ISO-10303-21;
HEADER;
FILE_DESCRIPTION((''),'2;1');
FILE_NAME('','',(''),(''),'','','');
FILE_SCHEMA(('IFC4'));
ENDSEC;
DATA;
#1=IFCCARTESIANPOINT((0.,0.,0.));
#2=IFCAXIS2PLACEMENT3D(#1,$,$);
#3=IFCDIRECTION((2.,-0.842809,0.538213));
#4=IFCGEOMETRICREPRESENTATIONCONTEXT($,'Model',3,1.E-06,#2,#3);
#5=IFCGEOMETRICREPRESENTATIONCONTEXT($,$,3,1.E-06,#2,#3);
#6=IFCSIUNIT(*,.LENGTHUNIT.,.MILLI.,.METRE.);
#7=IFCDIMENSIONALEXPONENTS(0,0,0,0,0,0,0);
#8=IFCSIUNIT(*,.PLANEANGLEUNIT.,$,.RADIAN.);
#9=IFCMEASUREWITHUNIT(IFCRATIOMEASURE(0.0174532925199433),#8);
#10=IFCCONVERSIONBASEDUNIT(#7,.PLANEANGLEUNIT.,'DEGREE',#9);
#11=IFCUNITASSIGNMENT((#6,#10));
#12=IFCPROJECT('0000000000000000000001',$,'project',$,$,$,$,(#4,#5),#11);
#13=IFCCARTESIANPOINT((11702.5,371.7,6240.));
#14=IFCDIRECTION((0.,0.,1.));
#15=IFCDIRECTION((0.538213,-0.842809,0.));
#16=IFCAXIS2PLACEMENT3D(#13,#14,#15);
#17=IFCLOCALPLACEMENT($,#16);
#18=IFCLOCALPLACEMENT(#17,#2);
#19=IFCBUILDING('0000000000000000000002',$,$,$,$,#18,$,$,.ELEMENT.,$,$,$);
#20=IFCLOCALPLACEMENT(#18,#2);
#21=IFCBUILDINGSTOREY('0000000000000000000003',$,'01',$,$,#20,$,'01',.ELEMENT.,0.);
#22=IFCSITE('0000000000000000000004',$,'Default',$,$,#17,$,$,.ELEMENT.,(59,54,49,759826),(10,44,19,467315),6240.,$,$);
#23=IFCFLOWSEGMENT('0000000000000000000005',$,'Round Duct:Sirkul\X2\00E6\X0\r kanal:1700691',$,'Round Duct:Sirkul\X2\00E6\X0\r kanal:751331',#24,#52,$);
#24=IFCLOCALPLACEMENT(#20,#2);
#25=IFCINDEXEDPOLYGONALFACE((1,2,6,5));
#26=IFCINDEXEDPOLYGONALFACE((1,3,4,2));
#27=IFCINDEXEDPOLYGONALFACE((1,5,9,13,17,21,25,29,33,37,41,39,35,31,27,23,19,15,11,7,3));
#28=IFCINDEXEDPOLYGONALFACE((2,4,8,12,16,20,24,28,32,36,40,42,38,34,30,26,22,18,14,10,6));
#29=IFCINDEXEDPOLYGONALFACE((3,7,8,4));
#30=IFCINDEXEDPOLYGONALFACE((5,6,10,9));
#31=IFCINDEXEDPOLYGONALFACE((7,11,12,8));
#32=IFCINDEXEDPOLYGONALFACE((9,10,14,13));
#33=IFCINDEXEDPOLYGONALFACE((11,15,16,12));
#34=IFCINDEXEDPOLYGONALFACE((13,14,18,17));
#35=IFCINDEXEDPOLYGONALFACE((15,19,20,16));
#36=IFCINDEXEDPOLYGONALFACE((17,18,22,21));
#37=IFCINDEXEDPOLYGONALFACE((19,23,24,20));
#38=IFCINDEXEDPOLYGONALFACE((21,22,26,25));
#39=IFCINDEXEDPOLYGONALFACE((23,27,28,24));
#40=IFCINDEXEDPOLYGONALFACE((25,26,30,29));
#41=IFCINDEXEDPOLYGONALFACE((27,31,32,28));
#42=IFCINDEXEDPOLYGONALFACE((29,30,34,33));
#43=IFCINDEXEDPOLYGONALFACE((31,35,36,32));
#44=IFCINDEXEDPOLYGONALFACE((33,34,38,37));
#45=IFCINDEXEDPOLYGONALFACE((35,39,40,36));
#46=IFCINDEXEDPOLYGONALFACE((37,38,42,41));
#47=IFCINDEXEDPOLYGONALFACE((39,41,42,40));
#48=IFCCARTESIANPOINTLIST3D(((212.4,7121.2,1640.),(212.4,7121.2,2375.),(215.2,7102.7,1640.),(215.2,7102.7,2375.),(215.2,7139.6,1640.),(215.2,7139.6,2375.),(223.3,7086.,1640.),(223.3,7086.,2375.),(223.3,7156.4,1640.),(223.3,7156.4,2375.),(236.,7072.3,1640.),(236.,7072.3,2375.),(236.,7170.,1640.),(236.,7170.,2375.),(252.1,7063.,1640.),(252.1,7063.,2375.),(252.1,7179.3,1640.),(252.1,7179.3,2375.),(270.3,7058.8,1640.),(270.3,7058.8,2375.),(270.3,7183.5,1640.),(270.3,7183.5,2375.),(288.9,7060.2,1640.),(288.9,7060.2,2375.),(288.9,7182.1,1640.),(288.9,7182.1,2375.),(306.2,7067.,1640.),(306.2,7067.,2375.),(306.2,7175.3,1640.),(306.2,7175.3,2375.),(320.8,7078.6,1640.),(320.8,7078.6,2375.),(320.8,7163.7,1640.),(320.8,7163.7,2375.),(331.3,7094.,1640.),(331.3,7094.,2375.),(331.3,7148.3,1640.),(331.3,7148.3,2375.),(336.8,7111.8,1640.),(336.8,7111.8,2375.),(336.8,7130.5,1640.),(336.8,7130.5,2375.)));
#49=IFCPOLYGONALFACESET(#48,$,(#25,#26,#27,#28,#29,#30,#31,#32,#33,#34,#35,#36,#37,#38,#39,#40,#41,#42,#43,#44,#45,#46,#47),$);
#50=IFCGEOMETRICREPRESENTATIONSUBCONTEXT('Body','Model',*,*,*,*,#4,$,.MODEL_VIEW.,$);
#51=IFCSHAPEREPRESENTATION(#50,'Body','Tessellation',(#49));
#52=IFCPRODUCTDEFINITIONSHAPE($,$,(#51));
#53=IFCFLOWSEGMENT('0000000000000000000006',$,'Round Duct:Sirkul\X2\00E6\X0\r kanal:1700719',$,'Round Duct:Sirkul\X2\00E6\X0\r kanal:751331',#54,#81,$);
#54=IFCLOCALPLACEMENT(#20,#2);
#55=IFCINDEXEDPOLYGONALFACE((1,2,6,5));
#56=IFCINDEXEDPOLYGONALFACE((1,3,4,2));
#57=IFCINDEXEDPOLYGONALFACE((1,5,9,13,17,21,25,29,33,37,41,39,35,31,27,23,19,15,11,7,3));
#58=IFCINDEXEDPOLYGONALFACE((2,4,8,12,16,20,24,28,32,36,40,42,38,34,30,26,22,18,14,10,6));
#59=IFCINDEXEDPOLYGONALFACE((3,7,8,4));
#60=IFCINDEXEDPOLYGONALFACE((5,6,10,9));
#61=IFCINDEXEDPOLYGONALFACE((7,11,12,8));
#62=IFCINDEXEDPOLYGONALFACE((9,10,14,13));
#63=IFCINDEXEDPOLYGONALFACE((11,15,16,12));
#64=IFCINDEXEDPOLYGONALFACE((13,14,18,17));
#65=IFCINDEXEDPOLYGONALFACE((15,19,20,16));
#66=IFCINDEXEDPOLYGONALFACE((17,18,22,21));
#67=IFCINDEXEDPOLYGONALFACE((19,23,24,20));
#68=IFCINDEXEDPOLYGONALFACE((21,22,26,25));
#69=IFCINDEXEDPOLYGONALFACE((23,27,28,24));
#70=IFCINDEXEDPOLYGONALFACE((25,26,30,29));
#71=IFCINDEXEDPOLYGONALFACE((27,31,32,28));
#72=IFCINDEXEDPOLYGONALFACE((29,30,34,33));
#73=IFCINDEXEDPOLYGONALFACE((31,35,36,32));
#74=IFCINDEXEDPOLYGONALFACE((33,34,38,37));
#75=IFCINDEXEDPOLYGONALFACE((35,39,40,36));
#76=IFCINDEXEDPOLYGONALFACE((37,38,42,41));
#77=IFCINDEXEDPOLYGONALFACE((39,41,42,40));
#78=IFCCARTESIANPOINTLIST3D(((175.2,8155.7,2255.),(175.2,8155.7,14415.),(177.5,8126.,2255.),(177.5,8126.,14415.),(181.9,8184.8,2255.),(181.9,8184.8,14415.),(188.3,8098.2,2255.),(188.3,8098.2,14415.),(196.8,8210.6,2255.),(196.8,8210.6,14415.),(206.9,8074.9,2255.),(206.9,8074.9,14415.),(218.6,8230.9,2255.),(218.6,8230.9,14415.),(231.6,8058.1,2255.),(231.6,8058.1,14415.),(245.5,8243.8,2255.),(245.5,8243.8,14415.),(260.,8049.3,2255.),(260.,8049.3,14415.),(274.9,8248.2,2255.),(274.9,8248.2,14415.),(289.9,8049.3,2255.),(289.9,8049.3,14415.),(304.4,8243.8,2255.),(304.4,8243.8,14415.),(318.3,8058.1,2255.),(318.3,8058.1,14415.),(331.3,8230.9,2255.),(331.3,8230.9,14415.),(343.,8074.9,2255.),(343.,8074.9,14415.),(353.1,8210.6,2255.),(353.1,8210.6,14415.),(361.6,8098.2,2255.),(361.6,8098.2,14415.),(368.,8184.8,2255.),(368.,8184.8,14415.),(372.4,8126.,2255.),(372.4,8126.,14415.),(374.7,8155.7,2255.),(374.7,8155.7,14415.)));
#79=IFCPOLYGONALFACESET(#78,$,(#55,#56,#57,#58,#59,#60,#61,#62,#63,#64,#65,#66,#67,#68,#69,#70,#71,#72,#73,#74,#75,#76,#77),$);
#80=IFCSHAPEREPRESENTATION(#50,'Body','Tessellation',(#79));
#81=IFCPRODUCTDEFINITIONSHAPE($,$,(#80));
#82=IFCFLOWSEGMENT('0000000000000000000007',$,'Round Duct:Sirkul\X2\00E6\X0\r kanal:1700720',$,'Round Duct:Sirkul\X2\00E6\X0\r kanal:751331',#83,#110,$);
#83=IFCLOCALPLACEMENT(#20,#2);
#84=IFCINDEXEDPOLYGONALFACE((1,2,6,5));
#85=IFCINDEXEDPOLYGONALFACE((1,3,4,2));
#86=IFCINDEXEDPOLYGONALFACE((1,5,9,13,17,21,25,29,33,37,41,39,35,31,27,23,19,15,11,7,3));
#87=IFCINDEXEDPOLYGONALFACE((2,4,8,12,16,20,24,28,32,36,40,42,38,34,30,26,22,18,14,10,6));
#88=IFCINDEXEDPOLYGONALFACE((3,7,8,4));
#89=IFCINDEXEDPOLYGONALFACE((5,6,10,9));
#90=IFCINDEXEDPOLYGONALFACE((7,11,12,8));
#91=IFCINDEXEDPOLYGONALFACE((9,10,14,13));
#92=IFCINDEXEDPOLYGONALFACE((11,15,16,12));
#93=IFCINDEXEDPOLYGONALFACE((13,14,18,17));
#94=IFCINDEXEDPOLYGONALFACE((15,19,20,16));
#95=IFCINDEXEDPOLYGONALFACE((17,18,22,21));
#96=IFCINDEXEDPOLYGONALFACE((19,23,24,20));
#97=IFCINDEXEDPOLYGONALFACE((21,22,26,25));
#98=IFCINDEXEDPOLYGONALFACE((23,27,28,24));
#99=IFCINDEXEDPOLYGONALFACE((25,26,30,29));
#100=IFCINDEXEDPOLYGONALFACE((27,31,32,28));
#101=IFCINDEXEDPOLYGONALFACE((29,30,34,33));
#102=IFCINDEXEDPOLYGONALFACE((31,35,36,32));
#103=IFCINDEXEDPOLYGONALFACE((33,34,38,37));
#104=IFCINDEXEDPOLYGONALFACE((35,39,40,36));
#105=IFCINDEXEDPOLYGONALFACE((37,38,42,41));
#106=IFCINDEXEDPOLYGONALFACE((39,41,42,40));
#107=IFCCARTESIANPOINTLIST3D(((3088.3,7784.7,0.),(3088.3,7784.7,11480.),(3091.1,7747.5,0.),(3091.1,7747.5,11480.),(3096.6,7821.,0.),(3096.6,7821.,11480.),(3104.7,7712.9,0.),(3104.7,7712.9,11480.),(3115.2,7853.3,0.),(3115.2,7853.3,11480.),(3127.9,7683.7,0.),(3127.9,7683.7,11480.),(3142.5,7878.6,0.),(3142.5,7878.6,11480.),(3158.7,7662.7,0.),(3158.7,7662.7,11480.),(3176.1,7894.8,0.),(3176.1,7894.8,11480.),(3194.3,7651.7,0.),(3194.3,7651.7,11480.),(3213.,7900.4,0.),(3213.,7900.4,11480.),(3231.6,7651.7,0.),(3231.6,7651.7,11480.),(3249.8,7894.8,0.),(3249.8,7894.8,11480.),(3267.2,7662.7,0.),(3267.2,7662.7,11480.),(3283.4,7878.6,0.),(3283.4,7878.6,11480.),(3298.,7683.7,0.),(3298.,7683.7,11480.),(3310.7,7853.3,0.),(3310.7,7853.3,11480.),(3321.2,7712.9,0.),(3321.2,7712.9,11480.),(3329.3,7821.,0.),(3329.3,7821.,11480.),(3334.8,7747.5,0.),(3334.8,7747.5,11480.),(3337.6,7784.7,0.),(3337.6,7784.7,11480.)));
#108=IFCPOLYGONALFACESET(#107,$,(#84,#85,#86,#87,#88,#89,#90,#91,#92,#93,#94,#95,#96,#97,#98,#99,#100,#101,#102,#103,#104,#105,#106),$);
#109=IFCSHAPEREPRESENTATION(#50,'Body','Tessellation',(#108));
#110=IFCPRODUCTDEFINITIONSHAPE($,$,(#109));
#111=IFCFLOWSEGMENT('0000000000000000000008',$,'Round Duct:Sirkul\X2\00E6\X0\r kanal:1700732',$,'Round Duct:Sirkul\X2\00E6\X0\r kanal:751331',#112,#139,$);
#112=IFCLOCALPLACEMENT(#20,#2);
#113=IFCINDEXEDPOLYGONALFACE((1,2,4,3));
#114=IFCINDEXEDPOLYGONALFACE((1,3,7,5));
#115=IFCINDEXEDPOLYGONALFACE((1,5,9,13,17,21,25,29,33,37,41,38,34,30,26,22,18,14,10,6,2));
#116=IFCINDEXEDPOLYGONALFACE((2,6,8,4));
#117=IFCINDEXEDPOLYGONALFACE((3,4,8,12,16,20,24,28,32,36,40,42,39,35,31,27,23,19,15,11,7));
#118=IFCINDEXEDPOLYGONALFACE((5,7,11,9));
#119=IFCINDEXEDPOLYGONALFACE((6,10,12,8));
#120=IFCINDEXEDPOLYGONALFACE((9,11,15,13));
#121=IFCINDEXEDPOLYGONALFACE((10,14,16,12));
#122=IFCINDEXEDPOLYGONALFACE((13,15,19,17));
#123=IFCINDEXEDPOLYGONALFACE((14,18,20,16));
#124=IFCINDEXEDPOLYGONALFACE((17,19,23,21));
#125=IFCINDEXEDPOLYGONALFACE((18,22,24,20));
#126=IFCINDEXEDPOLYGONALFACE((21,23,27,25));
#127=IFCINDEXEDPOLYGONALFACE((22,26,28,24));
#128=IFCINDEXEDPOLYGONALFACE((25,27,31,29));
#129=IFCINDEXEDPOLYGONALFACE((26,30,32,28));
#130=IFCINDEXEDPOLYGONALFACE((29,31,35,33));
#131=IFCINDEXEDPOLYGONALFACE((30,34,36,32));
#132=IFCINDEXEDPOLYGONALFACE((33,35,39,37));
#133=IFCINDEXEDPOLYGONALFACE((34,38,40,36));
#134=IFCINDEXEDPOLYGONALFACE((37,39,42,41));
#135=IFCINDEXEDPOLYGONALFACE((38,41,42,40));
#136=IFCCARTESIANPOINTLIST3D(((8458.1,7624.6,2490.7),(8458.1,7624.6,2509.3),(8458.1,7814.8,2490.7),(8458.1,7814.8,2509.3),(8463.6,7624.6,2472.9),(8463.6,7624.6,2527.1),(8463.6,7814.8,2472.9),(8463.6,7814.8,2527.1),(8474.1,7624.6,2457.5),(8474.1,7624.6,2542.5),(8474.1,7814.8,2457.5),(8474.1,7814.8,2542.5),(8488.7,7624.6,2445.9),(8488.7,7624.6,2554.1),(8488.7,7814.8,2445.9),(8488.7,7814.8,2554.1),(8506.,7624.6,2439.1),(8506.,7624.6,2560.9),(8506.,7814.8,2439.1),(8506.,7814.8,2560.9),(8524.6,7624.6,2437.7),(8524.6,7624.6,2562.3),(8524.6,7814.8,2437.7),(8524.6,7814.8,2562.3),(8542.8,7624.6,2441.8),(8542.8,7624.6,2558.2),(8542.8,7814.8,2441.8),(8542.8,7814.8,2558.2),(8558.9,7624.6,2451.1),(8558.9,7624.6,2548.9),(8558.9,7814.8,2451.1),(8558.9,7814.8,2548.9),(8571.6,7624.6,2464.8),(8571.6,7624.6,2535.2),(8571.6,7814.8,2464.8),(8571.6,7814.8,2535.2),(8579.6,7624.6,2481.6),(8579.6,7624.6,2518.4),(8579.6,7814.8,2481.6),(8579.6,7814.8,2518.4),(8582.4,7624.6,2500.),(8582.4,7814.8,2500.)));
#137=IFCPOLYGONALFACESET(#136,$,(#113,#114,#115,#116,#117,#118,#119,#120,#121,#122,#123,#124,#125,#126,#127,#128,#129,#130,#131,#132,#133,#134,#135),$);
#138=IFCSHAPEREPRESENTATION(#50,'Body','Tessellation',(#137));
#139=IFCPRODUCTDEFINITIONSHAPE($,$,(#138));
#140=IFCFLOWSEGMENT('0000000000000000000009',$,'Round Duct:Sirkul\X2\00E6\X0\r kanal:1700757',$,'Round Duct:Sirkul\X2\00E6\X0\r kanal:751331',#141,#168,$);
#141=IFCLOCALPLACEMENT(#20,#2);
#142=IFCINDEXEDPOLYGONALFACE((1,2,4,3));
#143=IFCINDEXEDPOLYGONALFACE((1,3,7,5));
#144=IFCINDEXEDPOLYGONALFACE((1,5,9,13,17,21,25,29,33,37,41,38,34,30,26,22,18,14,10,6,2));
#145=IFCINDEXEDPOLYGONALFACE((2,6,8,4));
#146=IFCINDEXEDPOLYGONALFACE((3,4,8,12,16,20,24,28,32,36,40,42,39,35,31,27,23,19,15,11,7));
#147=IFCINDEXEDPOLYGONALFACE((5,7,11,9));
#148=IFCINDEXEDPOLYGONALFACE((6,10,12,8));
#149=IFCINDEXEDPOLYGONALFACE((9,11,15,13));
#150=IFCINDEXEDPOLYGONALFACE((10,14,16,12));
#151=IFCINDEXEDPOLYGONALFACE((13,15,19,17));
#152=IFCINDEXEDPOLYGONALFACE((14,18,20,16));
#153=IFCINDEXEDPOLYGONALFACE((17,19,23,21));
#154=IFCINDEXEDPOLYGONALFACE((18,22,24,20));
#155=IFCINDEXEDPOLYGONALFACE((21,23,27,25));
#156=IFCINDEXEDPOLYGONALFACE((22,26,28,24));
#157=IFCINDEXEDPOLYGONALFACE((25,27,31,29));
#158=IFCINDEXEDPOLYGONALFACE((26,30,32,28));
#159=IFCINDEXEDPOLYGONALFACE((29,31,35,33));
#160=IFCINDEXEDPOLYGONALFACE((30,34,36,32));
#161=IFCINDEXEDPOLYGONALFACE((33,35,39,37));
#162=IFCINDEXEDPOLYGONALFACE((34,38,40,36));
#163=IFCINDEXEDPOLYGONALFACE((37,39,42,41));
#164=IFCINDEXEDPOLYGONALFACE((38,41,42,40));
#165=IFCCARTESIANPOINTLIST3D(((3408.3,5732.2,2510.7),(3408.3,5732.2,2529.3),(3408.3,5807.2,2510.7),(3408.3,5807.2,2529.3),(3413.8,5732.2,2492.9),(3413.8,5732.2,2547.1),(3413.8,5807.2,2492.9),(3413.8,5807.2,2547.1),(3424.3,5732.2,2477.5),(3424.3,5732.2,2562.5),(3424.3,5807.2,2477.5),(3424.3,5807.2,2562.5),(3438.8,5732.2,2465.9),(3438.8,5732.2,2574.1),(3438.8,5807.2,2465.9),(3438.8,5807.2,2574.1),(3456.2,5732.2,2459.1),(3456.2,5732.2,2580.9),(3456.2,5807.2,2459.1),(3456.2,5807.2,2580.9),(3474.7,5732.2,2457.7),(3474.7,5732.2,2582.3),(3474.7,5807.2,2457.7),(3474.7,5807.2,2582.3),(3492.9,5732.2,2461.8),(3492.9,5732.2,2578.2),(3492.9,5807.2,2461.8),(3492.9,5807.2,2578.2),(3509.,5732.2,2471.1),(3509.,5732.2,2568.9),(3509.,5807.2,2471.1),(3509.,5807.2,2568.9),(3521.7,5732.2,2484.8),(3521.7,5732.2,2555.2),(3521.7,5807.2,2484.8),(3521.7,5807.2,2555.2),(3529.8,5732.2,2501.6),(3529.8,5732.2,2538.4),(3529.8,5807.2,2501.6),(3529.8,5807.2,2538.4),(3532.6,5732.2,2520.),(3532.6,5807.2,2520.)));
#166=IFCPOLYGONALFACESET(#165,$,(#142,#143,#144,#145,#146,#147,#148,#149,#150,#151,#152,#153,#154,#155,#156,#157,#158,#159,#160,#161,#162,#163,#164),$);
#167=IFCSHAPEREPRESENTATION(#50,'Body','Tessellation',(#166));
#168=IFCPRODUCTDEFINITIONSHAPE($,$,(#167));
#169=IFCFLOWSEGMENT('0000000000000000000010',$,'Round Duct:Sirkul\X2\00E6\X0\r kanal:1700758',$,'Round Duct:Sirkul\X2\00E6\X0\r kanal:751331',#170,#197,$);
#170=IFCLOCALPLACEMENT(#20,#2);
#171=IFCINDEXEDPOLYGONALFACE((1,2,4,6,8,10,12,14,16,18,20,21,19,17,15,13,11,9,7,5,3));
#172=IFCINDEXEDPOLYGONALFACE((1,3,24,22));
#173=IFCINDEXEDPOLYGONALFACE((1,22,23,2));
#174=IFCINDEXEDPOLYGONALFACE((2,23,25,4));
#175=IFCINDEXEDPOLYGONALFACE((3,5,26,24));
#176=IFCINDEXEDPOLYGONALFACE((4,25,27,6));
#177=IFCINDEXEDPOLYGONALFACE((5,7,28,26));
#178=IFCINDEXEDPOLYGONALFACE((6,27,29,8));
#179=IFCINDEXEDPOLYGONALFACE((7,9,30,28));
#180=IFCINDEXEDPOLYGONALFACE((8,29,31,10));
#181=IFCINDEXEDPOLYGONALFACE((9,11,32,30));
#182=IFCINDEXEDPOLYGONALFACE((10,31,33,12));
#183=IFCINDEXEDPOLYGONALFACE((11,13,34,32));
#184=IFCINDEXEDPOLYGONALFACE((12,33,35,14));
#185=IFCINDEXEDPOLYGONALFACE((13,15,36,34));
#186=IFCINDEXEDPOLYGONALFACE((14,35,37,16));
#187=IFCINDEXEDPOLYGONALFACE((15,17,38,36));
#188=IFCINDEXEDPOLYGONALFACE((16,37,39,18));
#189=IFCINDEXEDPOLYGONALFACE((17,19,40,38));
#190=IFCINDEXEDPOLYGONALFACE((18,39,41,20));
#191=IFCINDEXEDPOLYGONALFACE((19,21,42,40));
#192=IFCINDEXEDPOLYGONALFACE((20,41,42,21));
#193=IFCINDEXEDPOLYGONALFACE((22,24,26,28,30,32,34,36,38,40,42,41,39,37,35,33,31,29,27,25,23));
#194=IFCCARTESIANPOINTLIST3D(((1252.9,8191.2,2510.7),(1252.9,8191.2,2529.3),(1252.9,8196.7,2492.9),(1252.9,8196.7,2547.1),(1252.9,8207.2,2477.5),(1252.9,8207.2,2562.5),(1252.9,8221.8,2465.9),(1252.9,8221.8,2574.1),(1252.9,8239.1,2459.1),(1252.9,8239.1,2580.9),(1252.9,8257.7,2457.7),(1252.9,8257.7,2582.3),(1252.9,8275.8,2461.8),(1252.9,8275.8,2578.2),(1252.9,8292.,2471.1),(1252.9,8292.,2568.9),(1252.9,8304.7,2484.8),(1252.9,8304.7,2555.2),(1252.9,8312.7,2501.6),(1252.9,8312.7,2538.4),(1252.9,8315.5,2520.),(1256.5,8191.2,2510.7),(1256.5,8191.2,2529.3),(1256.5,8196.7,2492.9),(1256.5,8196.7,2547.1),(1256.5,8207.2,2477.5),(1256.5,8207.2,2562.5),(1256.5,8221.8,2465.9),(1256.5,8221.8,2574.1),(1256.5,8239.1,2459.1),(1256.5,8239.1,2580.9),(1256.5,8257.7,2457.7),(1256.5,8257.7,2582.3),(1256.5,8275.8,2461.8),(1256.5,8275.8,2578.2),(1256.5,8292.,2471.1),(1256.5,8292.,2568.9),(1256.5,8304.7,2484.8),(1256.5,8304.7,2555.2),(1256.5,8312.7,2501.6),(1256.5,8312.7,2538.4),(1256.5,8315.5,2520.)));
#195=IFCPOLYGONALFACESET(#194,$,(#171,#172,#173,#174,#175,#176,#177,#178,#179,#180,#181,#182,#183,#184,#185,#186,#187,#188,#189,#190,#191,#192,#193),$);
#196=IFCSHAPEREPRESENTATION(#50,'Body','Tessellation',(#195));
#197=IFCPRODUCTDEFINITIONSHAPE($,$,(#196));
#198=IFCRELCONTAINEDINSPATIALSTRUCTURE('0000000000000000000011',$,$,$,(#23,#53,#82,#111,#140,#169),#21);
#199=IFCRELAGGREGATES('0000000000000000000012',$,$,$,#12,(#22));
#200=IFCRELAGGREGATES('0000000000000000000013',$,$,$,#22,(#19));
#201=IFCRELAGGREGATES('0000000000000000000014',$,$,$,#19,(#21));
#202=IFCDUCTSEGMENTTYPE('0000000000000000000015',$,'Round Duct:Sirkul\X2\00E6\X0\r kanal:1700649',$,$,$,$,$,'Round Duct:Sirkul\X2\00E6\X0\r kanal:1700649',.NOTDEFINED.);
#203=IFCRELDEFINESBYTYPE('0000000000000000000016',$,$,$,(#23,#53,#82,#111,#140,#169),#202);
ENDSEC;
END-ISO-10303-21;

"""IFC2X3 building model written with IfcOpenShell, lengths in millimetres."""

from ifc_helpers import new_model, entity, si_unit, converted_unit, direction, frame, frame_2d, origin, origin_2d_with_axis, place, context, subcontext, project, spatial, circle, extrude, type_object, element, save


model = new_model("IFC2X3")

# Units and contexts
model_context = context("Model", 3, precision=1e-06, world=origin(), true_north=direction((2.0, -0.842809, 0.538213)))
context_of_model = context(None, 3, precision=1e-06, world=origin(), true_north=direction((2.0, -0.842809, 0.538213)))
body_context = subcontext(model_context, "Body", "Model", "MODEL_VIEW")
ifc_project = project(units=[si_unit("LENGTHUNIT", "METRE", prefix="MILLI"), converted_unit("PLANEANGLEUNIT", "DEGREE", entity("IfcRatioMeasure", 0.0174532925199433), si_unit("PLANEANGLEUNIT", "RADIAN"), dimensions=[0, 0, 0, 0, 0, 0, 0])], contexts=[model_context, context_of_model])

# Site, building, storey
site_placement = place(None, frame((11702.5, 371.7, 6240.0), z_axis=(0.0, 0.0, 1.0), x_axis=(0.538213, -0.842809, 0.0)))
site = spatial("IfcSite", under=ifc_project, at=site_placement, Name="Default", CompositionType="ELEMENT", RefLatitude=(59, 54, 49, 759826), RefLongitude=(10, 44, 19, 467315), RefElevation=6240.0)
building_placement = place(site_placement, origin())
building = spatial("IfcBuilding", under=site, at=building_placement, CompositionType="ELEMENT")
storey_placement = place(building_placement, origin())
storey = spatial("IfcBuildingStorey", under=building, at=storey_placement, Name="01", LongName="01", CompositionType="ELEMENT", Elevation=0.0)

# Flow segments
duct_segment_type = type_object("IfcDuctSegmentType", Name="Round Duct:Sirkulær kanal:1700649", ElementType="Round Duct:Sirkulær kanal:1700649", PredefinedType="NOTDEFINED")
flow_segment_1_placement = place(storey_placement, origin())
element("IfcFlowSegment", 1, at=flow_segment_1_placement, inside=storey, type_object=duct_segment_type, Name="Round Duct:Sirkulær kanal:1700691", ObjectType="Round Duct:Sirkulær kanal:751331", context=body_context, shape_type="SweptSolid", body=[
    extrude(circle(Radius=62.5, at=frame_2d((0.0, 0.0), x_axis=(1.0, 0.0))), frame((274.9, 7121.2, 1640.0), z_axis=(0.0, 0.0, 1.0), x_axis=(-1.0, 0.0, 0.0)), (0.0, 0.0, 1.0), 735.0),
])
flow_segment_2_placement = place(storey_placement, origin())
element("IfcFlowSegment", 2, at=flow_segment_2_placement, inside=storey, type_object=duct_segment_type, Name="Round Duct:Sirkulær kanal:1700719", ObjectType="Round Duct:Sirkulær kanal:751331", context=body_context, shape_type="SweptSolid", body=[
    extrude(circle(Radius=100.0, at=frame_2d((0.0, 0.0), x_axis=(1.0, 0.0))), frame((274.9, 8148.2, 2255.0), z_axis=(0.0, 0.0, 1.0), x_axis=(0.0, 1.0, 0.0)), (0.0, 0.0, 1.0), 12160.0),
])
flow_segment_3_placement = place(storey_placement, origin())
element("IfcFlowSegment", 3, at=flow_segment_3_placement, inside=storey, type_object=duct_segment_type, Name="Round Duct:Sirkulær kanal:1700720", ObjectType="Round Duct:Sirkulær kanal:751331", context=body_context, shape_type="SweptSolid", body=[
    extrude(circle(Radius=125.0, at=frame_2d((0.0, 0.0), x_axis=(1.0, 0.0))), frame((3213.0, 7775.4, 0.0), z_axis=(0.0, 0.0, 1.0), x_axis=(0.0, 1.0, 0.0)), (0.0, 0.0, 1.0), 11480.0),
])
flow_segment_4_placement = place(storey_placement, origin())
element("IfcFlowSegment", 4, at=flow_segment_4_placement, inside=storey, type_object=duct_segment_type, Name="Round Duct:Sirkulær kanal:1700732", ObjectType="Round Duct:Sirkulær kanal:751331", context=body_context, shape_type="SweptSolid", body=[
    extrude(circle(Radius=62.5, at=origin_2d_with_axis()), frame((8519.9, 7624.6, 2500.0), z_axis=(0.0, 1.0, 0.0), x_axis=(1.0, 0.0, 0.0)), (0.0, 0.0, 1.0), 190.1),
])
flow_segment_5_placement = place(storey_placement, origin())
element("IfcFlowSegment", 5, at=flow_segment_5_placement, inside=storey, type_object=duct_segment_type, Name="Round Duct:Sirkulær kanal:1700757", ObjectType="Round Duct:Sirkulær kanal:751331", context=body_context, shape_type="SweptSolid", body=[
    extrude(circle(Radius=62.5, at=frame_2d((0.0, 0.0), x_axis=(1.0, 0.0))), frame((3470.1, 5732.2, 2520.0), z_axis=(0.0, 1.0, 0.0), x_axis=(1.0, 0.0, 0.0)), (0.0, 0.0, 1.0), 75.0),
])
flow_segment_6_placement = place(storey_placement, origin())
element("IfcFlowSegment", 6, at=flow_segment_6_placement, inside=storey, type_object=duct_segment_type, Name="Round Duct:Sirkulær kanal:1700758", ObjectType="Round Duct:Sirkulær kanal:751331", context=body_context, shape_type="SweptSolid", body=[
    extrude(circle(Radius=62.5, at=frame_2d((0.0, 0.0), x_axis=(1.0, 0.0))), frame((1252.9, 8253.0, 2520.0), z_axis=(1.0, 0.0, 0.0), x_axis=(0.0, 1.0, 0.0)), (0.0, 0.0, 1.0), 3.6),
])

save(model, "model.ifc")
